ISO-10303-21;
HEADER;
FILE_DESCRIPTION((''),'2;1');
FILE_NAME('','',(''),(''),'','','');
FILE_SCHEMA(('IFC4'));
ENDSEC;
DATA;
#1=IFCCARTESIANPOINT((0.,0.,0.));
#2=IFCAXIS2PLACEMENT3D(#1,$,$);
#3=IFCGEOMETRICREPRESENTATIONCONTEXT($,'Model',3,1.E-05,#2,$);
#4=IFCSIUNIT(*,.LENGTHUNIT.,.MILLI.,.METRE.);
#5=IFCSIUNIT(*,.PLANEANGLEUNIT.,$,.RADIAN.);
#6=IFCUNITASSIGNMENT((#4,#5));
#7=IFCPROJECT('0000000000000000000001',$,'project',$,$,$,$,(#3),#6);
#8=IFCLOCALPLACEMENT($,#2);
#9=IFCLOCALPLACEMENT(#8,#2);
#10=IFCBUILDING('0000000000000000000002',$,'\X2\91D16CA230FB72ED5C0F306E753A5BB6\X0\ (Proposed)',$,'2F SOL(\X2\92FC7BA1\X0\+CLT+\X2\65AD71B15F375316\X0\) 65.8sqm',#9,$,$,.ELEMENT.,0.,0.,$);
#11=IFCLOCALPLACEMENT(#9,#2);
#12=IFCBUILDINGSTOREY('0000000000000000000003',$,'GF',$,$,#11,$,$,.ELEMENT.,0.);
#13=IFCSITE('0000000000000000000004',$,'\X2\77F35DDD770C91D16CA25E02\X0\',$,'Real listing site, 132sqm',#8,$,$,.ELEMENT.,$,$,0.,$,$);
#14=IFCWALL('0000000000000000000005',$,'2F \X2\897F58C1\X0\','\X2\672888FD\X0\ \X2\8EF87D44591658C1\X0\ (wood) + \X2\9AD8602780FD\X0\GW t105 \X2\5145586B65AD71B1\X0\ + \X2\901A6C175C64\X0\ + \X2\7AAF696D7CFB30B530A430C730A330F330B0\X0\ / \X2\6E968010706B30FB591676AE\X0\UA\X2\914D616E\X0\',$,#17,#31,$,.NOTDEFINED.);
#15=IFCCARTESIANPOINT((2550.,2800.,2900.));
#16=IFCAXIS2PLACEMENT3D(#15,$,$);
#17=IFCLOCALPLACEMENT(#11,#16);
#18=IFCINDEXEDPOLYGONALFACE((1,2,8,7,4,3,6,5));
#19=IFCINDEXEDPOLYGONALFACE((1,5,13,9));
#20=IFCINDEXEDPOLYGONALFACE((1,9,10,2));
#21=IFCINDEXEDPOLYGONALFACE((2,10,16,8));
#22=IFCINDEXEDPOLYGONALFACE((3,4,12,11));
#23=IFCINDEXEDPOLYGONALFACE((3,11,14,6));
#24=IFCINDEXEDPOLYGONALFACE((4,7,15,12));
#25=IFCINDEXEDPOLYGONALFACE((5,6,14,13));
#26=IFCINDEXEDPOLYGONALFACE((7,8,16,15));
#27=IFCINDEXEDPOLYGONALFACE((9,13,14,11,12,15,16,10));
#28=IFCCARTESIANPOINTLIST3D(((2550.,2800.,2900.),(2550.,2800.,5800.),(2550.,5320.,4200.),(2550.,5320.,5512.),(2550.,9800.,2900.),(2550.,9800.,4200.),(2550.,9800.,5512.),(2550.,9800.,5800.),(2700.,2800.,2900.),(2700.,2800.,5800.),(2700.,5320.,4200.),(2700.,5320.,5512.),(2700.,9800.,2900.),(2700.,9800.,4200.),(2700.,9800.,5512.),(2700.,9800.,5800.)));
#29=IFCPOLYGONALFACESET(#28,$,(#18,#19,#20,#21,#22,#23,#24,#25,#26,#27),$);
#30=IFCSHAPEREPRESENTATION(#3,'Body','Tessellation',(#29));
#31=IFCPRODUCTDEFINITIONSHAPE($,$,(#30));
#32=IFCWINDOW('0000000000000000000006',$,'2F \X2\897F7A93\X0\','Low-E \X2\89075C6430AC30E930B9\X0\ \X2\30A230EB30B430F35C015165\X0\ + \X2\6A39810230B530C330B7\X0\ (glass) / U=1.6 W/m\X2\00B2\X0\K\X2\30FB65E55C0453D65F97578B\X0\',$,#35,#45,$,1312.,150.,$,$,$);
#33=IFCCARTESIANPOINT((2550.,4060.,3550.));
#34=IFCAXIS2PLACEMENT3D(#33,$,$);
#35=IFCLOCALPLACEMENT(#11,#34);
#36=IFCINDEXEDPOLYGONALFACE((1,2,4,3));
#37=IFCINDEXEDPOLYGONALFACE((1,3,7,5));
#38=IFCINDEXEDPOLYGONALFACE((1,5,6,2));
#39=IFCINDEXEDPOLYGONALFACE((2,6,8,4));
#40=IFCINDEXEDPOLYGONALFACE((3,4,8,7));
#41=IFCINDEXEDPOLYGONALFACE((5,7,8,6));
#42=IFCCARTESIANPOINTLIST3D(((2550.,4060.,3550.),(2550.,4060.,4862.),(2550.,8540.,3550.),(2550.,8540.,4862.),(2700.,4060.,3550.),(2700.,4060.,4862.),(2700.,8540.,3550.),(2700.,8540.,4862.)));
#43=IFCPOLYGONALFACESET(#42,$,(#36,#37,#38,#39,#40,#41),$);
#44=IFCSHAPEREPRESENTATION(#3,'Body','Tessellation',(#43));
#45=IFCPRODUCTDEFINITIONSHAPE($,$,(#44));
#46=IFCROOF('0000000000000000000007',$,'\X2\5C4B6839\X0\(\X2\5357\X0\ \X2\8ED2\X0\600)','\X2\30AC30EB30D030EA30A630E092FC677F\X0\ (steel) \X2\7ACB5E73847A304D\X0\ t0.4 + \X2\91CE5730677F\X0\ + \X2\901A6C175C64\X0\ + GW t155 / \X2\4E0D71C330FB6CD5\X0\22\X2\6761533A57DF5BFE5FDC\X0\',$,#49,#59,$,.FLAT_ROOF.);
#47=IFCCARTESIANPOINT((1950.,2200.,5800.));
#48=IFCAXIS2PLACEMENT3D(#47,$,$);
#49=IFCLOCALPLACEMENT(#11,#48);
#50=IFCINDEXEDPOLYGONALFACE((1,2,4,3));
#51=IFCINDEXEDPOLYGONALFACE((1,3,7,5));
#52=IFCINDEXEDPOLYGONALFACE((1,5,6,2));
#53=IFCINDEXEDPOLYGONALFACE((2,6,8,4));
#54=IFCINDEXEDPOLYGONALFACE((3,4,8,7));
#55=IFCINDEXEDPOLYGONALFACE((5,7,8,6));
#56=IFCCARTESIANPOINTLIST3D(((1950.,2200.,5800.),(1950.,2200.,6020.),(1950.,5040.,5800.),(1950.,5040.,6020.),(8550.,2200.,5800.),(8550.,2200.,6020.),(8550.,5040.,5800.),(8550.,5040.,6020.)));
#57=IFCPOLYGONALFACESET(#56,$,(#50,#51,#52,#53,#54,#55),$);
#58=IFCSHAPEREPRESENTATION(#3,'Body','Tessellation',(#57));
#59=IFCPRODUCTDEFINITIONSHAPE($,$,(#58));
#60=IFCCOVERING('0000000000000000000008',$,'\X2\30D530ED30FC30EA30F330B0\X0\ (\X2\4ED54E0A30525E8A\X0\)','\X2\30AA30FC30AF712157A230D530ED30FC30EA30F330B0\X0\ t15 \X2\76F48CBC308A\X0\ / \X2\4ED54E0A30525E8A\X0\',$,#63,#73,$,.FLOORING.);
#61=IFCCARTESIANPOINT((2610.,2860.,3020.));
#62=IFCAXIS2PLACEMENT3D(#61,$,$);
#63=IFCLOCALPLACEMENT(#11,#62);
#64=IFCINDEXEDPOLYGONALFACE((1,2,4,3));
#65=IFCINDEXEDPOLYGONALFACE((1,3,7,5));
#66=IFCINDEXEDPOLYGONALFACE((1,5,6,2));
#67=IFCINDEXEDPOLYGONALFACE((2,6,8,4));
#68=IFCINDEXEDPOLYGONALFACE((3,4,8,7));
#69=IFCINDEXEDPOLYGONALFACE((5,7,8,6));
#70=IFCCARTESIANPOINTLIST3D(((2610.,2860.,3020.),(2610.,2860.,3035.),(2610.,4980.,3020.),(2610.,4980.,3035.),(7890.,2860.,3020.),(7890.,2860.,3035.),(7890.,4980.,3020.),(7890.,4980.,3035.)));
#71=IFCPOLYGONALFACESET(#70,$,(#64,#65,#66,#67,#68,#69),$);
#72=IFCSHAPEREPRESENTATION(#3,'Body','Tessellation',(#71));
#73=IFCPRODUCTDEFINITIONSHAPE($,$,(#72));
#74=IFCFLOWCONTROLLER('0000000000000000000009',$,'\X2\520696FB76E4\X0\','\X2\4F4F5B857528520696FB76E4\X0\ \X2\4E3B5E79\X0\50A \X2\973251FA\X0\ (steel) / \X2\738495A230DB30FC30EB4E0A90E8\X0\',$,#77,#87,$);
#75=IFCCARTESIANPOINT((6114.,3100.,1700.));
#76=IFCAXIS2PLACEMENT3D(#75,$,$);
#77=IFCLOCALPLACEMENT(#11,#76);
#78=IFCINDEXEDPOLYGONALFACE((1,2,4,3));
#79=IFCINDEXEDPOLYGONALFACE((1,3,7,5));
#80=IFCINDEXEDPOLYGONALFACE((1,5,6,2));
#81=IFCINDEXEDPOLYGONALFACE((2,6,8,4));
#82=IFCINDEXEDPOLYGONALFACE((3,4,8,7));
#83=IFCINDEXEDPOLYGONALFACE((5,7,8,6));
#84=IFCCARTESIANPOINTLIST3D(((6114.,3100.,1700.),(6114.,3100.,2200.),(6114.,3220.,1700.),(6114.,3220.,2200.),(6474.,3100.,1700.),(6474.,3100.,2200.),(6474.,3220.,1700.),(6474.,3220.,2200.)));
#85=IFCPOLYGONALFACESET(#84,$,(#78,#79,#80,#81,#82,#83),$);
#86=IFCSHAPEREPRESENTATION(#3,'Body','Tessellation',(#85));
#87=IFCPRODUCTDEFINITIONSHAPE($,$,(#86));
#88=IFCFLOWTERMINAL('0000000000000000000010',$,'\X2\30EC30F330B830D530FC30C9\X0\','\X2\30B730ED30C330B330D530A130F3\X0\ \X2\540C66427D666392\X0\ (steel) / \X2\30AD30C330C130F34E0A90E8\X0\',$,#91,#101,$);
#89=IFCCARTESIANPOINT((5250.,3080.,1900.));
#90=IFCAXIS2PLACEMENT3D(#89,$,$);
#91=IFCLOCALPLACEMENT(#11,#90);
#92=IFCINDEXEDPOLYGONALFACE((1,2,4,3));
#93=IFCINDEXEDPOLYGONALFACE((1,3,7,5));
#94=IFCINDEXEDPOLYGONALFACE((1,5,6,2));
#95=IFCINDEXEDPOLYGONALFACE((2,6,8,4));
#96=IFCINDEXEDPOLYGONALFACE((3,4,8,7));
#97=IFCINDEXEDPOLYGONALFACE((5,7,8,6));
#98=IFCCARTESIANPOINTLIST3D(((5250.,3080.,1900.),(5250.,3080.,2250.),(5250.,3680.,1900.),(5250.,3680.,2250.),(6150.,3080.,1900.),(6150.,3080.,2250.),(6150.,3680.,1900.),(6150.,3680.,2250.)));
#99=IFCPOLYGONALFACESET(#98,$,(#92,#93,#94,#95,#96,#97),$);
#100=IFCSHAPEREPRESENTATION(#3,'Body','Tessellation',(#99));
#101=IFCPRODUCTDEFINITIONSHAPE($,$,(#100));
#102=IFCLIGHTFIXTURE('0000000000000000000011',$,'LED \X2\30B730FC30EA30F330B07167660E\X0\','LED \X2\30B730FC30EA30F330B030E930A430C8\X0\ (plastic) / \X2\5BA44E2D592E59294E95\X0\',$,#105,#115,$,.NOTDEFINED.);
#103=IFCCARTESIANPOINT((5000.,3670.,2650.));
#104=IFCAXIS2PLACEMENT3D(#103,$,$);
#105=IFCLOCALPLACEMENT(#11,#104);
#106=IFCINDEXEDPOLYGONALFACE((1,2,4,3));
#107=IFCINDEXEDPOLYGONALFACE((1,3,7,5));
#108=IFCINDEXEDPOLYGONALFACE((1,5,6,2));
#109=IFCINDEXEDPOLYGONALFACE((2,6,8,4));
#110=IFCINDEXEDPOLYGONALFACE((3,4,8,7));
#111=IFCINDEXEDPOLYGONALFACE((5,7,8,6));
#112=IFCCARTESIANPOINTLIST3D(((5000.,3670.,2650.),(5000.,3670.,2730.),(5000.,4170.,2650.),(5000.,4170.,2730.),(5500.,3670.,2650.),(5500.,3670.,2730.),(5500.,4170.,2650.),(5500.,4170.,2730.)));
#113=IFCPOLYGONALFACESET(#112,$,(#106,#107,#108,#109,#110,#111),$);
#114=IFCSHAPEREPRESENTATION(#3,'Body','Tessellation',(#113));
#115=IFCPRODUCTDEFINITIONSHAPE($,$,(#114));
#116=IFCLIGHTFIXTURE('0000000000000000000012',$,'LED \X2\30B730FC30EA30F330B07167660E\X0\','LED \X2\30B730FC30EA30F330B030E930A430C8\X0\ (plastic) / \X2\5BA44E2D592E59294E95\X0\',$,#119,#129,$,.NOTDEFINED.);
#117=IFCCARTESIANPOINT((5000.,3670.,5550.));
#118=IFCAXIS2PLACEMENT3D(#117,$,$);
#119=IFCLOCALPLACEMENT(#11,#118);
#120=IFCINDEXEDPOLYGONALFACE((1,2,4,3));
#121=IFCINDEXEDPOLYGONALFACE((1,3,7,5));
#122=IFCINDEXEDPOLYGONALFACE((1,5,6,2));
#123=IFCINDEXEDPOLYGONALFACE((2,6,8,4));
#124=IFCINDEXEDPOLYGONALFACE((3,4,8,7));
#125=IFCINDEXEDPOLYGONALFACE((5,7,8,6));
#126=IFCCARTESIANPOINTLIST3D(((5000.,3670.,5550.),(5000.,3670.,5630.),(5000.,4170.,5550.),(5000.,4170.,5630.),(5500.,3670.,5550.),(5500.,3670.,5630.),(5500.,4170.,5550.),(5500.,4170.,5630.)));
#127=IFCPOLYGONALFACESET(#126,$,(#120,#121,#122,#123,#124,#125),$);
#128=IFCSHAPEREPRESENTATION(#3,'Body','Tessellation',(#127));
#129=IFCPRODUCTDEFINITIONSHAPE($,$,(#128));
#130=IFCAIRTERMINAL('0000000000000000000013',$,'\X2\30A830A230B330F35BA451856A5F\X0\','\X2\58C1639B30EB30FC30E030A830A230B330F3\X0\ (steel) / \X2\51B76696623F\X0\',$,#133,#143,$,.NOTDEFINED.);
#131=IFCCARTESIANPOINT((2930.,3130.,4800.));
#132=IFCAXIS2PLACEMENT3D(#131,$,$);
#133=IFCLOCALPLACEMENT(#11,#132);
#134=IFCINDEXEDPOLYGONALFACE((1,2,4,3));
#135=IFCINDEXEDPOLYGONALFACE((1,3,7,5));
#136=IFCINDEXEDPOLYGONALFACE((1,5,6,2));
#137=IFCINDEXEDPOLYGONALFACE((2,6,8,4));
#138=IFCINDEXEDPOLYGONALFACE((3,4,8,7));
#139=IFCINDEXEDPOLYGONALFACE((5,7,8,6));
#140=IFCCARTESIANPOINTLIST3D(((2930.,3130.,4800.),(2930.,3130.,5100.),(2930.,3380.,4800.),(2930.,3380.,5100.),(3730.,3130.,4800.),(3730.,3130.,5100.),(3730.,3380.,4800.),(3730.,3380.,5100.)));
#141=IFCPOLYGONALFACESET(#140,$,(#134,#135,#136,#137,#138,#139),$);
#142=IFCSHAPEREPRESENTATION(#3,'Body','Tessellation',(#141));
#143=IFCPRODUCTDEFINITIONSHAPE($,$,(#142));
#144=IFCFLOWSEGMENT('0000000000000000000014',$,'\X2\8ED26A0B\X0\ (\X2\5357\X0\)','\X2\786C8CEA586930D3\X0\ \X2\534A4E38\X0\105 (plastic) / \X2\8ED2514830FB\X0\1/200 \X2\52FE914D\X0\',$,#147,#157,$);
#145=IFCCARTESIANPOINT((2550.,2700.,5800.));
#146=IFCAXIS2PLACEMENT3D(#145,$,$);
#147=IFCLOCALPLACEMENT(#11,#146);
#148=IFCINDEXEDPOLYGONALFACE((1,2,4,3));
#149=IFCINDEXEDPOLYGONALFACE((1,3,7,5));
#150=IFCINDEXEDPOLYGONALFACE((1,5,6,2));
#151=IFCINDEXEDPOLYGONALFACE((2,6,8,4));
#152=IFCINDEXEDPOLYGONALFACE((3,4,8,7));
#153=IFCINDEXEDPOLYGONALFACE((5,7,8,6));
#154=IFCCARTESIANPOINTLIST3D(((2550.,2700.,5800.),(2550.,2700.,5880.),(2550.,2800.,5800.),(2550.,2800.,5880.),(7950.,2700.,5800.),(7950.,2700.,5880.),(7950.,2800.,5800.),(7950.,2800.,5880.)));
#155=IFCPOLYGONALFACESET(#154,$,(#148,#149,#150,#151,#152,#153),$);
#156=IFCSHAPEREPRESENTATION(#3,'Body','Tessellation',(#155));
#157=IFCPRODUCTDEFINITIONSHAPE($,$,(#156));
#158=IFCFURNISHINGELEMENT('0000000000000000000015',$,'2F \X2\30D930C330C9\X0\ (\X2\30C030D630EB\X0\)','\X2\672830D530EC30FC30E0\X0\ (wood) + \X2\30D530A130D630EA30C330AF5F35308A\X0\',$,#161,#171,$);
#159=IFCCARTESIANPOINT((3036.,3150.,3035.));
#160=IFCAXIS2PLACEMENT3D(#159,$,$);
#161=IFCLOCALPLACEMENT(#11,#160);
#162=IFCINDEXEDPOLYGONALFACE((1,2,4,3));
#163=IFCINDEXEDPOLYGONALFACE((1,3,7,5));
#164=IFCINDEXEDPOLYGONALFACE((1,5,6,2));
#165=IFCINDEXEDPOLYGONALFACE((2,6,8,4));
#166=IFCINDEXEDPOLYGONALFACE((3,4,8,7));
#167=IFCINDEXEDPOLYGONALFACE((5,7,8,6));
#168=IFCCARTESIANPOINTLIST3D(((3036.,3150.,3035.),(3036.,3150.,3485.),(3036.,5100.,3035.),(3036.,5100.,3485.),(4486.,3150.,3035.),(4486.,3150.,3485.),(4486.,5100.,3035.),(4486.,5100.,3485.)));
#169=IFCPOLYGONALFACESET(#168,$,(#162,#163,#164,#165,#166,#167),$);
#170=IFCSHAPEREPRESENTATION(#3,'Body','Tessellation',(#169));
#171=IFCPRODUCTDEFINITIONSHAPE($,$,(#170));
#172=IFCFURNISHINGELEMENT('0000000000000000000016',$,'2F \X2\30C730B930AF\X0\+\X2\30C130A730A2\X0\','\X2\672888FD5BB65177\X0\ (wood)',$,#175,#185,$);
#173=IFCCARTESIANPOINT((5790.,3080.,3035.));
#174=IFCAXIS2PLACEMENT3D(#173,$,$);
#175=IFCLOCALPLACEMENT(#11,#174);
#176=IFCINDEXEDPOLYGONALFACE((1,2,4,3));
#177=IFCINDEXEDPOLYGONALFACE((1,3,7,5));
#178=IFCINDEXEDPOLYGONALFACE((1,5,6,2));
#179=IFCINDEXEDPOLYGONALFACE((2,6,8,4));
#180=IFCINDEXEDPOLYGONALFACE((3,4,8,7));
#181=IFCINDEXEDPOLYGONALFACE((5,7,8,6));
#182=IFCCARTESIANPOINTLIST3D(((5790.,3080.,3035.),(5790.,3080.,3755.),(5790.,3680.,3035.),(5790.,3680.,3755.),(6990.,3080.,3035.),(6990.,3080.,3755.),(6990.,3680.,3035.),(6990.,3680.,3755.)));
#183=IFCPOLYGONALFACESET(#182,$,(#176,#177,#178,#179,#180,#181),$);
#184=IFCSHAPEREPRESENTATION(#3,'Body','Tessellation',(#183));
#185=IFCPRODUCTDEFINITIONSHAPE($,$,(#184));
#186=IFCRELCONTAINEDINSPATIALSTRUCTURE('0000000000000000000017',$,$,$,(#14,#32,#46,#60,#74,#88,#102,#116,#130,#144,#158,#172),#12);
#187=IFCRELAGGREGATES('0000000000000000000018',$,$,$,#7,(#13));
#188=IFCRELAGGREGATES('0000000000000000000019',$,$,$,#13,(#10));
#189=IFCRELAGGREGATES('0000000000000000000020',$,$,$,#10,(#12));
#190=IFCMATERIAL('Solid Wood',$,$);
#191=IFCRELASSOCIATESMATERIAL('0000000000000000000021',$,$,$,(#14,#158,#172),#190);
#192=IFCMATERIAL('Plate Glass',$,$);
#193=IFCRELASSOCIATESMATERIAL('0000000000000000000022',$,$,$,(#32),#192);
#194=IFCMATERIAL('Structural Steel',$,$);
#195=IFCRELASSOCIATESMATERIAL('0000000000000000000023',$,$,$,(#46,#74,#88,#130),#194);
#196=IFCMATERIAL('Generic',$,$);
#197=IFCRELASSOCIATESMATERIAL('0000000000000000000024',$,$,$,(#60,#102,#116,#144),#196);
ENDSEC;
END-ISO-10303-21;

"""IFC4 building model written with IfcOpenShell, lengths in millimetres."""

from ifc_helpers import new_model, si_unit, frame, frame_2d, origin, place, context, project, spatial, rectangle, extrude, material, element, fill, save


model = new_model("IFC4")

# Units and contexts
model_context = context("Model", 3, precision=1e-05, world=origin())
ifc_project = project(units=[si_unit("LENGTHUNIT", "METRE", prefix="MILLI"), si_unit("PLANEANGLEUNIT", "RADIAN")], contexts=[model_context])

# Site, building, storey
site_placement = place(None, origin())
site = spatial("IfcSite", under=ifc_project, at=site_placement, Name="石川県金沢市", ObjectType="Real listing site, 132sqm", CompositionType="ELEMENT", RefElevation=0.0)
building_placement = place(site_placement, origin())
building = spatial("IfcBuilding", under=site, at=building_placement, Name="金沢・狭小の町家 (Proposed)", ObjectType="2F SOL(鋼管+CLT+断熱強化) 65.8sqm", CompositionType="ELEMENT", ElevationOfRefHeight=0.0, ElevationOfTerrain=0.0)
storey_placement = place(building_placement, origin())
storey = spatial("IfcBuildingStorey", under=building, at=storey_placement, Name="GF", CompositionType="ELEMENT", Elevation=0.0)

# Shared definitions
ifc_material_1 = material(Name="Solid Wood")

# Wall, opening, window
ifc_material_2 = material(Name="Plate Glass")
wall_1_placement = place(storey_placement, frame((2550.0, 2800.0, 2900.0)))
wall_1 = element("IfcWall", 1, at=wall_1_placement, inside=storey, material=ifc_material_1, Name="2F 西壁", Description="木製 軸組外壁 (wood) + 高性能GW t105 充填断熱 + 通気層 + 窯業系サイディング / 準耐火・外皮UA配慮", PredefinedType="NOTDEFINED", context=model_context, shape_type="SweptSolid", body=[
    extrude(rectangle(XDim=150.0, YDim=7000.0, at=frame_2d((75.0, 3500.0))), frame((2550.0, 2800.0, 2900.0)), (0.0, 0.0, 1.0), 2900.0),
])
opening_1_placement = place(storey_placement, frame((2550.0, 4060.0, 3550.0)))
opening_1 = element("IfcOpeningElement", 2, at=opening_1_placement, cuts=wall_1, PredefinedType="NOTDEFINED", context=model_context, shape_type="SweptSolid", body=[
    extrude(rectangle(XDim=150.0, YDim=4480.0, at=frame_2d((75.0, 2240.0))), frame((2550.0, 4060.0, 3550.0)), (0.0, 0.0, 1.0), 1312.0),
])
window_1_placement = place(storey_placement, frame((2550.0, 4060.0, 3550.0)))
window_1 = element("IfcWindow", 3, at=window_1_placement, inside=storey, material=ifc_material_2, Name="2F 西窓", Description="Low-E 複層ガラス アルゴン封入 + 樹脂サッシ (glass) / U=1.6 W/m²K・日射取得型", OverallHeight=1312.0, OverallWidth=150.0, context=model_context, shape_type="SweptSolid", body=[
    extrude(rectangle(XDim=150.0, YDim=4480.0, at=frame_2d((75.0, 2240.0))), frame((2550.0, 4060.0, 3550.0)), (0.0, 0.0, 1.0), 1312.0),
])
fill(opening_1, window_1)

# Roof
ifc_material_3 = material(Name="Structural Steel")
for number, where, name in (
    (4, (1950.0, 2200.0, 5800.0), "屋根(南 軒600)"),
):
    element("IfcRoof", number, at=place(storey_placement, frame(where)), inside=storey, material=ifc_material_3, Name=name, Description="ガルバリウム鋼板 (steel) 立平葺き t0.4 + 野地板 + 通気層 + GW t155 / 不燃・法22条区域対応", PredefinedType="FLAT_ROOF", context=model_context, shape_type="SweptSolid", body=[
        extrude(rectangle(XDim=6600.0, YDim=2840.0, at=frame_2d((3300.0, 1420.0))), frame((1950.0, 2200.0, 5800.0)), (0.0, 0.0, 1.0), 220.0),
    ])

# Covering
ifc_material_4 = material(Name="Generic")
covering_placement = place(storey_placement, frame((2610.0, 2860.0, 3020.0)))
element("IfcCovering", 5, at=covering_placement, inside=storey, material=ifc_material_4, Name="フローリング (仕上げ床)", Description="オーク無垢フローリング t15 直貼り / 仕上げ床", PredefinedType="FLOORING", context=model_context, shape_type="SweptSolid", body=[
    extrude(rectangle(XDim=5280.0, YDim=2120.0, at=frame_2d((2640.0, 1060.0))), frame((2610.0, 2860.0, 3020.0)), (0.0, 0.0, 1.0), 15.0),
])

# Flow controller
flow_controller_placement = place(storey_placement, frame((6114.0, 3100.0, 1700.0)))
element("IfcFlowController", 6, at=flow_controller_placement, inside=storey, material=ifc_material_3, Name="分電盤", Description="住宅用分電盤 主幹50A 露出 (steel) / 玄関ホール上部", context=model_context, shape_type="SweptSolid", body=[
    extrude(rectangle(XDim=360.0, YDim=120.0, at=frame_2d((180.0, 60.0))), frame((6114.0, 3100.0, 1700.0)), (0.0, 0.0, 1.0), 500.0),
])

# Flow terminal
flow_terminal_placement = place(storey_placement, frame((5250.0, 3080.0, 1900.0)))
element("IfcFlowTerminal", 7, at=flow_terminal_placement, inside=storey, material=ifc_material_3, Name="レンジフード", Description="シロッコファン 同時給排 (steel) / キッチン上部", context=model_context, shape_type="SweptSolid", body=[
    extrude(rectangle(XDim=900.0, YDim=600.0, at=frame_2d((450.0, 300.0))), frame((5250.0, 3080.0, 1900.0)), (0.0, 0.0, 1.0), 350.0),
])

# Light fixtures
light_fixture_1_placement = place(storey_placement, frame((5000.0, 3670.0, 2650.0)))
element("IfcLightFixture", 8, at=light_fixture_1_placement, inside=storey, material=ifc_material_4, Name="LED シーリング照明", Description="LED シーリングライト (plastic) / 室中央天井", PredefinedType="NOTDEFINED", context=model_context, shape_type="SweptSolid", body=[
    extrude(rectangle(XDim=500.0, YDim=500.0, at=frame_2d((250.0, 250.0))), frame((5000.0, 3670.0, 2650.0)), (0.0, 0.0, 1.0), 80.0),
])
light_fixture_2_placement = place(storey_placement, frame((5000.0, 3670.0, 5550.0)))
element("IfcLightFixture", 9, at=light_fixture_2_placement, inside=storey, material=ifc_material_4, Name="LED シーリング照明", Description="LED シーリングライト (plastic) / 室中央天井", PredefinedType="NOTDEFINED", context=model_context, shape_type="SweptSolid", body=[
    extrude(rectangle(XDim=500.0, YDim=500.0, at=frame_2d((250.0, 250.0))), frame((5000.0, 3670.0, 5550.0)), (0.0, 0.0, 1.0), 80.0),
])

# Air terminal
air_terminal_placement = place(storey_placement, frame((2930.0, 3130.0, 4800.0)))
element("IfcAirTerminal", 10, at=air_terminal_placement, inside=storey, material=ifc_material_3, Name="エアコン室内機", Description="壁掛ルームエアコン (steel) / 冷暖房", PredefinedType="NOTDEFINED", context=model_context, shape_type="SweptSolid", body=[
    extrude(rectangle(XDim=800.0, YDim=250.0, at=frame_2d((400.0, 125.0))), frame((2930.0, 3130.0, 4800.0)), (0.0, 0.0, 1.0), 300.0),
])

# Flow segment
flow_segment_placement = place(storey_placement, frame((2550.0, 2700.0, 5800.0)))
element("IfcFlowSegment", 11, at=flow_segment_placement, inside=storey, material=ifc_material_4, Name="軒樋 (南)", Description="硬質塩ビ 半丸105 (plastic) / 軒先・1/200 勾配", context=model_context, shape_type="SweptSolid", body=[
    extrude(rectangle(XDim=5400.0, YDim=100.0, at=frame_2d((2700.0, 50.0))), frame((2550.0, 2700.0, 5800.0)), (0.0, 0.0, 1.0), 80.0),
])

# Furnishing elements
furnishing_1_placement = place(storey_placement, frame((3036.0, 3150.0, 3035.0)))
element("IfcFurnishingElement", 12, at=furnishing_1_placement, inside=storey, material=ifc_material_1, Name="2F ベッド (ダブル)", Description="木フレーム (wood) + ファブリック張り", context=model_context, shape_type="SweptSolid", body=[
    extrude(rectangle(XDim=1450.0, YDim=1950.0, at=frame_2d((725.0, 975.0))), frame((3036.0, 3150.0, 3035.0)), (0.0, 0.0, 1.0), 450.0),
])
furnishing_2_placement = place(storey_placement, frame((5790.0, 3080.0, 3035.0)))
element("IfcFurnishingElement", 13, at=furnishing_2_placement, inside=storey, material=ifc_material_1, Name="2F デスク+チェア", Description="木製家具 (wood)", context=model_context, shape_type="SweptSolid", body=[
    extrude(rectangle(XDim=1200.0, YDim=600.0, at=frame_2d((600.0, 300.0))), frame((5790.0, 3080.0, 3035.0)), (0.0, 0.0, 1.0), 720.0),
])

save(model, "model.ifc")
